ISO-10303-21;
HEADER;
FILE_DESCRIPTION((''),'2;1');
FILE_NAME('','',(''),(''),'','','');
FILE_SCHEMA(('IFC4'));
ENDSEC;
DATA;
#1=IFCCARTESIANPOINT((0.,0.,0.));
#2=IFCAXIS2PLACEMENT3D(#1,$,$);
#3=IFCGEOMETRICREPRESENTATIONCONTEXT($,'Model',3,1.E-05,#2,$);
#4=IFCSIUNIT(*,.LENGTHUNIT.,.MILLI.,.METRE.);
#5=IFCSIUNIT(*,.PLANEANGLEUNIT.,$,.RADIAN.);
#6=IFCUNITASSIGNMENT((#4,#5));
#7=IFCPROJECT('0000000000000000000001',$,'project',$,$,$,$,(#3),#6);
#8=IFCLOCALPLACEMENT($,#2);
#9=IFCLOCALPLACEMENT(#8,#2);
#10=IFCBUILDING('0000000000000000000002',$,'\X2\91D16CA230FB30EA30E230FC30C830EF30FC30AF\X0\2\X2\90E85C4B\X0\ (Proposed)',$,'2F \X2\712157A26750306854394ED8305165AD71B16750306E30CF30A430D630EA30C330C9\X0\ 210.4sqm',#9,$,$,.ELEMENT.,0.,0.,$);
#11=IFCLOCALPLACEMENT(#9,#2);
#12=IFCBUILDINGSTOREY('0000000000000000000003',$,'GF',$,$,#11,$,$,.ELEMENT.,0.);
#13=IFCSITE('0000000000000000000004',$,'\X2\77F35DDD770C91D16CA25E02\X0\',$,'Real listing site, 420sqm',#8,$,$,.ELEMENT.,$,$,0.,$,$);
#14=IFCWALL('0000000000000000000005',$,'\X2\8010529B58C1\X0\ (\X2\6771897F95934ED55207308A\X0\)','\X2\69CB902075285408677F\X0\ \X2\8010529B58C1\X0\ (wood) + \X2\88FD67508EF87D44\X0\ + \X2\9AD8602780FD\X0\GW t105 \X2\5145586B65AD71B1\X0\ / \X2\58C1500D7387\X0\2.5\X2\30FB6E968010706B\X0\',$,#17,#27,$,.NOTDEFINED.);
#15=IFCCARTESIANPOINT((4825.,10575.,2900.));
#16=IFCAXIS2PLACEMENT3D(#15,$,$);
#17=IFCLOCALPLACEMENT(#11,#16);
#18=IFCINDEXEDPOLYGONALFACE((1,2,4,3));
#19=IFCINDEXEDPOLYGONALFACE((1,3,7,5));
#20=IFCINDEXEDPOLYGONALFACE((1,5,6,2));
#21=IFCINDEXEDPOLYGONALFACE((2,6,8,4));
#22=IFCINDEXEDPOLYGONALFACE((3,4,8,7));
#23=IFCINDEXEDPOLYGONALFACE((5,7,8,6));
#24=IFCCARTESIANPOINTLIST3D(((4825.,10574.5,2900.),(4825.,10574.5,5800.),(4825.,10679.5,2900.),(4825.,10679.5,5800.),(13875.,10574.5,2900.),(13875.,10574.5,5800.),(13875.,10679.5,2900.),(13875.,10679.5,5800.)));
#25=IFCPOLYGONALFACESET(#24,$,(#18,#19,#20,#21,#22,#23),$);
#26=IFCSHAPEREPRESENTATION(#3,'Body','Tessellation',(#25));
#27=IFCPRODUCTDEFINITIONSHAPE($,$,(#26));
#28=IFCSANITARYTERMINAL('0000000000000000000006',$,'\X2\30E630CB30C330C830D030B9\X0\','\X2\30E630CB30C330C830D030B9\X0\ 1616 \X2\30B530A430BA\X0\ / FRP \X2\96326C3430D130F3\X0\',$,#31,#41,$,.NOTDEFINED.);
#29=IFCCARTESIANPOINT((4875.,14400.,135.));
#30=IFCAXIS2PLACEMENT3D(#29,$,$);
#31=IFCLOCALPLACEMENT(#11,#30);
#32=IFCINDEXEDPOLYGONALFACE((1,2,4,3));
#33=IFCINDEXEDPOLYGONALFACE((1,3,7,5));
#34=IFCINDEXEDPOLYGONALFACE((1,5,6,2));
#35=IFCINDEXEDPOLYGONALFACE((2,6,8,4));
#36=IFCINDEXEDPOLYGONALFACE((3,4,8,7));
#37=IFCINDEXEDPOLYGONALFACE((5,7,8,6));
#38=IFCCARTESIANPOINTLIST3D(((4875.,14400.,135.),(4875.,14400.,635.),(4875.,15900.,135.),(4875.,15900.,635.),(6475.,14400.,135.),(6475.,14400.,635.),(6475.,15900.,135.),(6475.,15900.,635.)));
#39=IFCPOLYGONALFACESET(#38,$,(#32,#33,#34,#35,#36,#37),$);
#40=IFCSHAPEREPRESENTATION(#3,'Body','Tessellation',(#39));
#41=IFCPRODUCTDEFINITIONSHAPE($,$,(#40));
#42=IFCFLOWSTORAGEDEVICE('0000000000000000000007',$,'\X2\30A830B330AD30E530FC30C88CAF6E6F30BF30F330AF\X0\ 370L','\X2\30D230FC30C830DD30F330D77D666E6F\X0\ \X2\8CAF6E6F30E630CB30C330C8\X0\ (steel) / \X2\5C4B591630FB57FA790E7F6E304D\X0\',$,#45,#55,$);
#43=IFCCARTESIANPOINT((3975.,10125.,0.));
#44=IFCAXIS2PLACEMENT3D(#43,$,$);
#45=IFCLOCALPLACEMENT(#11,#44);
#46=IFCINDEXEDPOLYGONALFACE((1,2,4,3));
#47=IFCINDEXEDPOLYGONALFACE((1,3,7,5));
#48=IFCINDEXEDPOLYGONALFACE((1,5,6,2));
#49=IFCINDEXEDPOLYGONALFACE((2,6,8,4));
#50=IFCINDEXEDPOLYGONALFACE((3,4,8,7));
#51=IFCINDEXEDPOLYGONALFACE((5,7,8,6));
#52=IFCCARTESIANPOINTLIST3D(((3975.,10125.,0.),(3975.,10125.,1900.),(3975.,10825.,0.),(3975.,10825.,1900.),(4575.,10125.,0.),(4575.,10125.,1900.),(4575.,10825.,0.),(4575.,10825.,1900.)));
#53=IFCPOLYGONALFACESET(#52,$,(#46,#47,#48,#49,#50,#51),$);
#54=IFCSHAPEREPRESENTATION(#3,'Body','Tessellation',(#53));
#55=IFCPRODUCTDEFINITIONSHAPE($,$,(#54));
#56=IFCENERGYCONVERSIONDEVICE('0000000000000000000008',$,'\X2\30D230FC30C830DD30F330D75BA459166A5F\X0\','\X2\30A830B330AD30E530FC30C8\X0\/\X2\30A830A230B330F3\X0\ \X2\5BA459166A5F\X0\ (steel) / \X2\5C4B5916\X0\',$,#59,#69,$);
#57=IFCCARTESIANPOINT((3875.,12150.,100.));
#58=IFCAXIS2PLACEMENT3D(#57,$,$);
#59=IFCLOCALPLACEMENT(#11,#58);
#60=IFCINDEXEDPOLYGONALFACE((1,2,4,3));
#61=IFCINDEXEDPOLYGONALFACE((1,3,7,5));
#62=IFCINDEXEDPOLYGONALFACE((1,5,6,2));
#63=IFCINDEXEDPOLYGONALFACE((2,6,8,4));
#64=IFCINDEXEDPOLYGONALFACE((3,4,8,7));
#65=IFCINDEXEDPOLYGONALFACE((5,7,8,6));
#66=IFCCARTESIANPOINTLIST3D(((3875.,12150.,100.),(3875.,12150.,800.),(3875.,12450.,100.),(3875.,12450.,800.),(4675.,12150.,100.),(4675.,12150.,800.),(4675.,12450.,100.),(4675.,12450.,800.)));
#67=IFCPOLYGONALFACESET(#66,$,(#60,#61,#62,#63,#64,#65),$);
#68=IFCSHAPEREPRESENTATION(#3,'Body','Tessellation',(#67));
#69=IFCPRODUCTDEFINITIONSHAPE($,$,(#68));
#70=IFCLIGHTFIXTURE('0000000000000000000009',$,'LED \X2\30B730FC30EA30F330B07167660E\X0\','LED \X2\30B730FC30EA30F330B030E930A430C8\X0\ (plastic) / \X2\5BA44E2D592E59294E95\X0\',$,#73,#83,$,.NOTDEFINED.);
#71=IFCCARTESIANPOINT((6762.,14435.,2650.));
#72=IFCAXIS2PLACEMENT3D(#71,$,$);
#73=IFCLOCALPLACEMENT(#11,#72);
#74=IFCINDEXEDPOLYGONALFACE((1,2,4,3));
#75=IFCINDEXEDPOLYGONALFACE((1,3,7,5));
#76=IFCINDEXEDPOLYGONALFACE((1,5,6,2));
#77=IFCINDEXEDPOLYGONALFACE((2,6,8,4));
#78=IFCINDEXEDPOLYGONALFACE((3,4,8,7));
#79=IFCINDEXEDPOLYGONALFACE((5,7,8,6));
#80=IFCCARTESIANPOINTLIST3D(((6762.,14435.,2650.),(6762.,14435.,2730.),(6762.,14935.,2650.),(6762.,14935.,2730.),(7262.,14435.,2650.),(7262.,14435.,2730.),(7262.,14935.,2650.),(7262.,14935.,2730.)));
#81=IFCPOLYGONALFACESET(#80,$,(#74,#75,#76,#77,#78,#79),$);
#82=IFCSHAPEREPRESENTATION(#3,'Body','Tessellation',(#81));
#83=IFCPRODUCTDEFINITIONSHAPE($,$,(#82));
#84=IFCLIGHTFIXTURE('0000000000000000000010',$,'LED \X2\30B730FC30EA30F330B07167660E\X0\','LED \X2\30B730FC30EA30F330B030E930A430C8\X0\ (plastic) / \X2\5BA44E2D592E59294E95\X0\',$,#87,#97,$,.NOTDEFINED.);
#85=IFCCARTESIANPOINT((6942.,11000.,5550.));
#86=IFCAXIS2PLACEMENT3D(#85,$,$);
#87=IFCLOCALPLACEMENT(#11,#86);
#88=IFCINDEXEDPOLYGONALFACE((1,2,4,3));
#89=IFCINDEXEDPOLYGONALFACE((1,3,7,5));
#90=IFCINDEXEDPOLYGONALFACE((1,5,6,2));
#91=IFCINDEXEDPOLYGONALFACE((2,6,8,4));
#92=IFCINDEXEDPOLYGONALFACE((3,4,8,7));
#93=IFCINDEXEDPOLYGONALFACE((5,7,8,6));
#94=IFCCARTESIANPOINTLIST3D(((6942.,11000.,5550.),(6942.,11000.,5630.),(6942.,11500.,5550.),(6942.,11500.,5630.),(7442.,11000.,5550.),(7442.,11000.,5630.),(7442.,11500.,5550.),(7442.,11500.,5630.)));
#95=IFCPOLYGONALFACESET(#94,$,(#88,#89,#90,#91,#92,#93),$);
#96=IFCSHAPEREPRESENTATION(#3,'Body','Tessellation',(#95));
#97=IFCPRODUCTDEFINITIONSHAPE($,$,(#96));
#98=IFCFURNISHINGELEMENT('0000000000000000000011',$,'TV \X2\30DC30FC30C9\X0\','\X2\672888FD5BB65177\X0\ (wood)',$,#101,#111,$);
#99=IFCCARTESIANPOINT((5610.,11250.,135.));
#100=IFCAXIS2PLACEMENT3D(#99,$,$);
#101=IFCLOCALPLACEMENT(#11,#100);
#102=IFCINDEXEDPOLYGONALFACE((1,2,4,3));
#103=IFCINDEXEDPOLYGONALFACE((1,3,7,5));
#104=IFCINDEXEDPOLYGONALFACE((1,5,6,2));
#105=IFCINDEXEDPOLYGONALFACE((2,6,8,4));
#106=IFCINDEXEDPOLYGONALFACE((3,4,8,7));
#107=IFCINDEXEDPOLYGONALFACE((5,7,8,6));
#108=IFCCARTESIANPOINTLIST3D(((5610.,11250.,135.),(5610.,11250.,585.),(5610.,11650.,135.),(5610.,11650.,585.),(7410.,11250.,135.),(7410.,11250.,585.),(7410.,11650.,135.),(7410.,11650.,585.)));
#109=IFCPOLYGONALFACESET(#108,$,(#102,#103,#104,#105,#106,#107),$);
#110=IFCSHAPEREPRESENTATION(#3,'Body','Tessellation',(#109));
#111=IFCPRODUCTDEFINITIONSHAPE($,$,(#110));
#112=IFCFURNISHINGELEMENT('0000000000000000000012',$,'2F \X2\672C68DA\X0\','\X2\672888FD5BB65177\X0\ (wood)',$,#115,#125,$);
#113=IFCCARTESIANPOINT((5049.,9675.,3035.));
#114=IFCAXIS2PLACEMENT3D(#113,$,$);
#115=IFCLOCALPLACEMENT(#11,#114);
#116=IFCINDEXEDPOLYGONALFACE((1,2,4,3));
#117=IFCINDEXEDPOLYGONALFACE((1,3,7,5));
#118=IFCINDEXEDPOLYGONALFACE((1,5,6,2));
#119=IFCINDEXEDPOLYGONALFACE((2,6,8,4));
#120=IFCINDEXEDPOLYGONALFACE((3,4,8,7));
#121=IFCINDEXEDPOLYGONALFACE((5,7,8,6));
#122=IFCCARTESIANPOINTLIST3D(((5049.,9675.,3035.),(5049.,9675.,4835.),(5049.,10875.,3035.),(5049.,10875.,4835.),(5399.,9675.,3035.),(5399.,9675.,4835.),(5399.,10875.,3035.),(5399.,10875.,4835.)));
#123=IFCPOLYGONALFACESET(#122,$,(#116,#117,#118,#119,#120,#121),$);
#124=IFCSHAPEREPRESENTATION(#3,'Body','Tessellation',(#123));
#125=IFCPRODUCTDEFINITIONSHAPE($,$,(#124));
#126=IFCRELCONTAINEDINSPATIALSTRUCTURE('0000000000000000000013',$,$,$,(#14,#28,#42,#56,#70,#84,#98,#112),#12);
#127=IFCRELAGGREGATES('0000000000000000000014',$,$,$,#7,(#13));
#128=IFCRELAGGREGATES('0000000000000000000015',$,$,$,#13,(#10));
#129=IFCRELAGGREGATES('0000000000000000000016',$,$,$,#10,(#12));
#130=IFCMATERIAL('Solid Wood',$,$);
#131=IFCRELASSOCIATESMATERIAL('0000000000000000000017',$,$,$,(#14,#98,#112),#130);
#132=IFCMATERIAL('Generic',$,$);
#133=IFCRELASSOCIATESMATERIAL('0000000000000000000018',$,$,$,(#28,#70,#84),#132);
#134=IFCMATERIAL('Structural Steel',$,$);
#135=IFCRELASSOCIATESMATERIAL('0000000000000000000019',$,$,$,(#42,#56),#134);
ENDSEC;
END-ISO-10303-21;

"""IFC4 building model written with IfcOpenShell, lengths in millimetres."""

from ifc_helpers import new_model, si_unit, frame, frame_2d, origin, place, context, project, spatial, rectangle, extrude, material, element, save


model = new_model("IFC4")

# Units and contexts
model_context = context("Model", 3, precision=1e-05, world=origin())
ifc_project = project(units=[si_unit("LENGTHUNIT", "METRE", prefix="MILLI"), si_unit("PLANEANGLEUNIT", "RADIAN")], contexts=[model_context])

# Site, building, storey
site_placement = place(None, origin())
site = spatial("IfcSite", under=ifc_project, at=site_placement, Name="石川県金沢市", ObjectType="Real listing site, 420sqm", CompositionType="ELEMENT", RefElevation=0.0)
building_placement = place(site_placement, origin())
building = spatial("IfcBuilding", under=site, at=building_placement, Name="金沢・リモートワーク2部屋 (Proposed)", ObjectType="2F 無垢材と吹付け断熱材のハイブリッド 210.4sqm", CompositionType="ELEMENT", ElevationOfRefHeight=0.0, ElevationOfTerrain=0.0)
storey_placement = place(building_placement, origin())
storey = spatial("IfcBuildingStorey", under=building, at=storey_placement, Name="GF", CompositionType="ELEMENT", Elevation=0.0)

# Shared definitions
ifc_material_1 = material(Name="Solid Wood")

# Wall
wall_1_placement = place(storey_placement, frame((4825.0, 10575.0, 2900.0)))
element("IfcWall", 1, at=wall_1_placement, inside=storey, material=ifc_material_1, Name="耐力壁 (東西間仕切り)", Description="構造用合板 耐力壁 (wood) + 製材軸組 + 高性能GW t105 充填断熱 / 壁倍率2.5・準耐火", PredefinedType="NOTDEFINED", context=model_context, shape_type="SweptSolid", body=[
    extrude(rectangle(XDim=9050.0, YDim=105.0, at=frame_2d((4525.0, 52.0))), frame((4825.0, 10575.0, 2900.0)), (0.0, 0.0, 1.0), 2900.0),
])

# Sanitary terminal
ifc_material_2 = material(Name="Generic")
sanitary_terminal_placement = place(storey_placement, frame((4875.0, 14400.0, 135.0)))
element("IfcSanitaryTerminal", 2, at=sanitary_terminal_placement, inside=storey, material=ifc_material_2, Name="ユニットバス", Description="ユニットバス 1616 サイズ / FRP 防水パン", PredefinedType="NOTDEFINED", context=model_context, shape_type="SweptSolid", body=[
    extrude(rectangle(XDim=1600.0, YDim=1500.0, at=frame_2d((800.0, 750.0))), frame((4875.0, 14400.0, 135.0)), (0.0, 0.0, 1.0), 500.0),
])

# Flow storage device
ifc_material_3 = material(Name="Structural Steel")
flow_storage_device_placement = place(storey_placement, frame((3975.0, 10125.0, 0.0)))
element("IfcFlowStorageDevice", 3, at=flow_storage_device_placement, inside=storey, material=ifc_material_3, Name="エコキュート貯湯タンク 370L", Description="ヒートポンプ給湯 貯湯ユニット (steel) / 屋外・基礎置き", context=model_context, shape_type="SweptSolid", body=[
    extrude(rectangle(XDim=600.0, YDim=700.0, at=frame_2d((300.0, 350.0))), frame((3975.0, 10125.0, 0.0)), (0.0, 0.0, 1.0), 1900.0),
])

# Energy conversion device
energy_conversion_device_placement = place(storey_placement, frame((3875.0, 12150.0, 100.0)))
element("IfcEnergyConversionDevice", 4, at=energy_conversion_device_placement, inside=storey, material=ifc_material_3, Name="ヒートポンプ室外機", Description="エコキュート/エアコン 室外機 (steel) / 屋外", context=model_context, shape_type="SweptSolid", body=[
    extrude(rectangle(XDim=800.0, YDim=300.0, at=frame_2d((400.0, 150.0))), frame((3875.0, 12150.0, 100.0)), (0.0, 0.0, 1.0), 700.0),
])

# Light fixtures
light_fixture_1_placement = place(storey_placement, frame((6762.0, 14435.0, 2650.0)))
element("IfcLightFixture", 5, at=light_fixture_1_placement, inside=storey, material=ifc_material_2, Name="LED シーリング照明", Description="LED シーリングライト (plastic) / 室中央天井", PredefinedType="NOTDEFINED", context=model_context, shape_type="SweptSolid", body=[
    extrude(rectangle(XDim=500.0, YDim=500.0, at=frame_2d((250.0, 250.0))), frame((6762.0, 14435.0, 2650.0)), (0.0, 0.0, 1.0), 80.0),
])
light_fixture_2_placement = place(storey_placement, frame((6942.0, 11000.0, 5550.0)))
element("IfcLightFixture", 6, at=light_fixture_2_placement, inside=storey, material=ifc_material_2, Name="LED シーリング照明", Description="LED シーリングライト (plastic) / 室中央天井", PredefinedType="NOTDEFINED", context=model_context, shape_type="SweptSolid", body=[
    extrude(rectangle(XDim=500.0, YDim=500.0, at=frame_2d((250.0, 250.0))), frame((6942.0, 11000.0, 5550.0)), (0.0, 0.0, 1.0), 80.0),
])

# Furnishing elements
furnishing_1_placement = place(storey_placement, frame((5610.0, 11250.0, 135.0)))
element("IfcFurnishingElement", 7, at=furnishing_1_placement, inside=storey, material=ifc_material_1, Name="TV ボード", Description="木製家具 (wood)", context=model_context, shape_type="SweptSolid", body=[
    extrude(rectangle(XDim=1800.0, YDim=400.0, at=frame_2d((900.0, 200.0))), frame((5610.0, 11250.0, 135.0)), (0.0, 0.0, 1.0), 450.0),
])
furnishing_2_placement = place(storey_placement, frame((5049.0, 9675.0, 3035.0)))
element("IfcFurnishingElement", 8, at=furnishing_2_placement, inside=storey, material=ifc_material_1, Name="2F 本棚", Description="木製家具 (wood)", context=model_context, shape_type="SweptSolid", body=[
    extrude(rectangle(XDim=350.0, YDim=1200.0, at=frame_2d((175.0, 600.0))), frame((5049.0, 9675.0, 3035.0)), (0.0, 0.0, 1.0), 1800.0),
])

save(model, "model.ifc")
